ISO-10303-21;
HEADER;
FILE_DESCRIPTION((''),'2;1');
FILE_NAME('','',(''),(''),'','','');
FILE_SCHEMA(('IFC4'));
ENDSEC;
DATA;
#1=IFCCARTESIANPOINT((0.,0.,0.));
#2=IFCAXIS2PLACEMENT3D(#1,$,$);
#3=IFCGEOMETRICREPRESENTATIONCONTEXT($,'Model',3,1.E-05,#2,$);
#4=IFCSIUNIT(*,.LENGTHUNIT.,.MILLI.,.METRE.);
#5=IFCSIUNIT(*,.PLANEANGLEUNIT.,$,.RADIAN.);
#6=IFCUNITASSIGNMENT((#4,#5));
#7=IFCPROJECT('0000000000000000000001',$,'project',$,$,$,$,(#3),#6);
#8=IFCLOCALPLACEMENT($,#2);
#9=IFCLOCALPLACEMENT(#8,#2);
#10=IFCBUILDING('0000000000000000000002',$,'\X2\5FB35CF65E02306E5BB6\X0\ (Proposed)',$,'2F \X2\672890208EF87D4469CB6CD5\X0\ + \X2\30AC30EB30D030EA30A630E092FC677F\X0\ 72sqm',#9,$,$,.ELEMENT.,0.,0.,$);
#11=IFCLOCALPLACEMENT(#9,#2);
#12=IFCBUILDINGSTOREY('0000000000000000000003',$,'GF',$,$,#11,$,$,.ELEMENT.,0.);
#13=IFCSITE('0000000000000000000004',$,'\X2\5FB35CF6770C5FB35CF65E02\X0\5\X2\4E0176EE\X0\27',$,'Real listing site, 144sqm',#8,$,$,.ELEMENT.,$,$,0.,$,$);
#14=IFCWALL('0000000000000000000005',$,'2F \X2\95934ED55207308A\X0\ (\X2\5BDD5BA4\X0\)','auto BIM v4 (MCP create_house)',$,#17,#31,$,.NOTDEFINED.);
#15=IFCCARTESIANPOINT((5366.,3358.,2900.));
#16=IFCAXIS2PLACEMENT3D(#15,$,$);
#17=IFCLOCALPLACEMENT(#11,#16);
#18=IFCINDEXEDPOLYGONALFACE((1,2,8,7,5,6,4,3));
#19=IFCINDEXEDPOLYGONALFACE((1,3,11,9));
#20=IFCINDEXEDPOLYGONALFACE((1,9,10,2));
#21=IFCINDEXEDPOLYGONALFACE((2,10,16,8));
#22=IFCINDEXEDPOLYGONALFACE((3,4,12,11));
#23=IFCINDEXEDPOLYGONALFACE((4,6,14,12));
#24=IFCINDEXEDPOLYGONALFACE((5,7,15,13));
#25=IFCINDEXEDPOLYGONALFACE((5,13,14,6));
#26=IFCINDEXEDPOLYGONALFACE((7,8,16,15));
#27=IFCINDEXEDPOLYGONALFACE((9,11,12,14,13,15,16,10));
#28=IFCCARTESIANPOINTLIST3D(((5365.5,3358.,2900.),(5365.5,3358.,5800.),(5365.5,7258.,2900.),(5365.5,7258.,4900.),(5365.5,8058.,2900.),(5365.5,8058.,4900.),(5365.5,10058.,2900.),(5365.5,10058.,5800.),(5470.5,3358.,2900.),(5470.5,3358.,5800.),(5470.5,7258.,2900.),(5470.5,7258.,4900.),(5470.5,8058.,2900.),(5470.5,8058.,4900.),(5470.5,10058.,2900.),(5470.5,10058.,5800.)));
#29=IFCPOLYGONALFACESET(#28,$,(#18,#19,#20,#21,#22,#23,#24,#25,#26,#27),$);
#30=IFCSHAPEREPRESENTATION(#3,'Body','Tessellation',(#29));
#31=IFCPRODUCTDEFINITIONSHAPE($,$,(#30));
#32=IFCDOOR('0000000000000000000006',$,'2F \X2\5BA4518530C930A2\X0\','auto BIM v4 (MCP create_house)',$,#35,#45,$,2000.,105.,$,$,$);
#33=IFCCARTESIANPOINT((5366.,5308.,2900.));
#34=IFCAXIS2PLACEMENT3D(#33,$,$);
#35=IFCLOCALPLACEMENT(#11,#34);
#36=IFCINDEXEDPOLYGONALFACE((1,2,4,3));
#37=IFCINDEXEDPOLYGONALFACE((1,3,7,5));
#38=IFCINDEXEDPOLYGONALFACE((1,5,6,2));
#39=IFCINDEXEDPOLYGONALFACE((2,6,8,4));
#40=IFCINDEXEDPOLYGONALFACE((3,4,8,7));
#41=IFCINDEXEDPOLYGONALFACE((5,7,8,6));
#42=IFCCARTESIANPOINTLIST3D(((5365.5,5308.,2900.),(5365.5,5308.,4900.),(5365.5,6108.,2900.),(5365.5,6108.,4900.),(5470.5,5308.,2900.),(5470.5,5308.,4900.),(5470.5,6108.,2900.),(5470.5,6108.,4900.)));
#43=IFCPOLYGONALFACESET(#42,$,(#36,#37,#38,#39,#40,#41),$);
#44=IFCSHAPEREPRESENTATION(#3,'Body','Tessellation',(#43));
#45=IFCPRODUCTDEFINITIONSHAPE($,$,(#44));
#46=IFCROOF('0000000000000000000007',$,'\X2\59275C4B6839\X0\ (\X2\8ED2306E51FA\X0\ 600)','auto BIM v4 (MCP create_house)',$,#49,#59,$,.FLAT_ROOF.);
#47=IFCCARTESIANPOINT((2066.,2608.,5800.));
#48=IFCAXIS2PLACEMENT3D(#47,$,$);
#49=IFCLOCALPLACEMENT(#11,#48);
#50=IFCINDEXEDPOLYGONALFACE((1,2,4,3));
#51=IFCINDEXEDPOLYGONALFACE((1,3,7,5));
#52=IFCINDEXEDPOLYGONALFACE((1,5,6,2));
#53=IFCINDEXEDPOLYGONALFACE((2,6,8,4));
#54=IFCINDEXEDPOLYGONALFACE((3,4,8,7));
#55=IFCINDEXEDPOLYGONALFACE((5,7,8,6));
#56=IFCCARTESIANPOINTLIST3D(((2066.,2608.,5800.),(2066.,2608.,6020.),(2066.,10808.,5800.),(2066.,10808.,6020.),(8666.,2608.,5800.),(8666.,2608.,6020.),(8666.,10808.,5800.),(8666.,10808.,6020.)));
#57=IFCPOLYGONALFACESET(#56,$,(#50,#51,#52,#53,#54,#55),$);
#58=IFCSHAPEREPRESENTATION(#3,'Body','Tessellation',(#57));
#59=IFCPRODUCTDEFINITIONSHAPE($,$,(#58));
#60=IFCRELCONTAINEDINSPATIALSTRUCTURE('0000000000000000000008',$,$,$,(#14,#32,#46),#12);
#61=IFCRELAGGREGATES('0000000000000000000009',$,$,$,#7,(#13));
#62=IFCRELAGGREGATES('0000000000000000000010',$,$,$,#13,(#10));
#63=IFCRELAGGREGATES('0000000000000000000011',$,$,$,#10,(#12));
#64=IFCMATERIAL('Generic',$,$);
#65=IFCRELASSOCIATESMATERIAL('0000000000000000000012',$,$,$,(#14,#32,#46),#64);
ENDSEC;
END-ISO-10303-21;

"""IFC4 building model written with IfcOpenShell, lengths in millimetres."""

from ifc_helpers import new_model, si_unit, frame, frame_2d, origin, place, context, project, spatial, rectangle, extrude, material, element, fill, save


model = new_model("IFC4")

# Units and contexts
model_context = context("Model", 3, precision=1e-05, world=origin())
ifc_project = project(units=[si_unit("LENGTHUNIT", "METRE", prefix="MILLI"), si_unit("PLANEANGLEUNIT", "RADIAN")], contexts=[model_context])

# Site, building, storey
site_placement = place(None, origin())
site = spatial("IfcSite", under=ifc_project, at=site_placement, Name="徳島県徳島市5丁目27", ObjectType="Real listing site, 144sqm", CompositionType="ELEMENT", RefElevation=0.0)
building_placement = place(site_placement, origin())
building = spatial("IfcBuilding", under=site, at=building_placement, Name="徳島市の家 (Proposed)", ObjectType="2F 木造軸組構法 + ガルバリウム鋼板 72sqm", CompositionType="ELEMENT", ElevationOfRefHeight=0.0, ElevationOfTerrain=0.0)
storey_placement = place(building_placement, origin())
storey = spatial("IfcBuildingStorey", under=building, at=storey_placement, Name="GF", CompositionType="ELEMENT", Elevation=0.0)

# Shared definitions
ifc_material = material(Name="Generic")

# Wall, opening, door
wall_1_placement = place(storey_placement, frame((5366.0, 3358.0, 2900.0)))
wall_1 = element("IfcWall", 1, at=wall_1_placement, inside=storey, material=ifc_material, Name="2F 間仕切り (寝室)", Description="auto BIM v4 (MCP create_house)", PredefinedType="NOTDEFINED", context=model_context, shape_type="SweptSolid", body=[
    extrude(rectangle(XDim=105.0, YDim=6700.0, at=frame_2d((52.0, 3350.0))), frame((5366.0, 3358.0, 2900.0)), (0.0, 0.0, 1.0), 2900.0),
])
opening_1_placement = place(storey_placement, frame((5366.0, 5308.0, 2900.0)))
opening_1 = element("IfcOpeningElement", 2, at=opening_1_placement, cuts=wall_1, PredefinedType="NOTDEFINED", context=model_context, shape_type="SweptSolid", body=[
    extrude(rectangle(XDim=105.0, YDim=800.0, at=frame_2d((52.0, 400.0))), frame((5366.0, 5308.0, 2900.0)), (0.0, 0.0, 1.0), 2000.0),
])
door_1_placement = place(storey_placement, frame((5366.0, 5308.0, 2900.0)))
door_1 = element("IfcDoor", 3, at=door_1_placement, inside=storey, material=ifc_material, Name="2F 室内ドア", Description="auto BIM v4 (MCP create_house)", OverallHeight=2000.0, OverallWidth=105.0, context=model_context, shape_type="SweptSolid", body=[
    extrude(rectangle(XDim=105.0, YDim=800.0, at=frame_2d((52.0, 400.0))), frame((5366.0, 5308.0, 2900.0)), (0.0, 0.0, 1.0), 2000.0),
])
fill(opening_1, door_1)

# Roof
roof_placement = place(storey_placement, frame((2066.0, 2608.0, 5800.0)))
element("IfcRoof", 4, at=roof_placement, inside=storey, material=ifc_material, Name="大屋根 (軒の出 600)", Description="auto BIM v4 (MCP create_house)", PredefinedType="FLAT_ROOF", context=model_context, shape_type="SweptSolid", body=[
    extrude(rectangle(XDim=6600.0, YDim=8200.0, at=frame_2d((3300.0, 4100.0))), frame((2066.0, 2608.0, 5800.0)), (0.0, 0.0, 1.0), 220.0),
])

save(model, "model.ifc")
